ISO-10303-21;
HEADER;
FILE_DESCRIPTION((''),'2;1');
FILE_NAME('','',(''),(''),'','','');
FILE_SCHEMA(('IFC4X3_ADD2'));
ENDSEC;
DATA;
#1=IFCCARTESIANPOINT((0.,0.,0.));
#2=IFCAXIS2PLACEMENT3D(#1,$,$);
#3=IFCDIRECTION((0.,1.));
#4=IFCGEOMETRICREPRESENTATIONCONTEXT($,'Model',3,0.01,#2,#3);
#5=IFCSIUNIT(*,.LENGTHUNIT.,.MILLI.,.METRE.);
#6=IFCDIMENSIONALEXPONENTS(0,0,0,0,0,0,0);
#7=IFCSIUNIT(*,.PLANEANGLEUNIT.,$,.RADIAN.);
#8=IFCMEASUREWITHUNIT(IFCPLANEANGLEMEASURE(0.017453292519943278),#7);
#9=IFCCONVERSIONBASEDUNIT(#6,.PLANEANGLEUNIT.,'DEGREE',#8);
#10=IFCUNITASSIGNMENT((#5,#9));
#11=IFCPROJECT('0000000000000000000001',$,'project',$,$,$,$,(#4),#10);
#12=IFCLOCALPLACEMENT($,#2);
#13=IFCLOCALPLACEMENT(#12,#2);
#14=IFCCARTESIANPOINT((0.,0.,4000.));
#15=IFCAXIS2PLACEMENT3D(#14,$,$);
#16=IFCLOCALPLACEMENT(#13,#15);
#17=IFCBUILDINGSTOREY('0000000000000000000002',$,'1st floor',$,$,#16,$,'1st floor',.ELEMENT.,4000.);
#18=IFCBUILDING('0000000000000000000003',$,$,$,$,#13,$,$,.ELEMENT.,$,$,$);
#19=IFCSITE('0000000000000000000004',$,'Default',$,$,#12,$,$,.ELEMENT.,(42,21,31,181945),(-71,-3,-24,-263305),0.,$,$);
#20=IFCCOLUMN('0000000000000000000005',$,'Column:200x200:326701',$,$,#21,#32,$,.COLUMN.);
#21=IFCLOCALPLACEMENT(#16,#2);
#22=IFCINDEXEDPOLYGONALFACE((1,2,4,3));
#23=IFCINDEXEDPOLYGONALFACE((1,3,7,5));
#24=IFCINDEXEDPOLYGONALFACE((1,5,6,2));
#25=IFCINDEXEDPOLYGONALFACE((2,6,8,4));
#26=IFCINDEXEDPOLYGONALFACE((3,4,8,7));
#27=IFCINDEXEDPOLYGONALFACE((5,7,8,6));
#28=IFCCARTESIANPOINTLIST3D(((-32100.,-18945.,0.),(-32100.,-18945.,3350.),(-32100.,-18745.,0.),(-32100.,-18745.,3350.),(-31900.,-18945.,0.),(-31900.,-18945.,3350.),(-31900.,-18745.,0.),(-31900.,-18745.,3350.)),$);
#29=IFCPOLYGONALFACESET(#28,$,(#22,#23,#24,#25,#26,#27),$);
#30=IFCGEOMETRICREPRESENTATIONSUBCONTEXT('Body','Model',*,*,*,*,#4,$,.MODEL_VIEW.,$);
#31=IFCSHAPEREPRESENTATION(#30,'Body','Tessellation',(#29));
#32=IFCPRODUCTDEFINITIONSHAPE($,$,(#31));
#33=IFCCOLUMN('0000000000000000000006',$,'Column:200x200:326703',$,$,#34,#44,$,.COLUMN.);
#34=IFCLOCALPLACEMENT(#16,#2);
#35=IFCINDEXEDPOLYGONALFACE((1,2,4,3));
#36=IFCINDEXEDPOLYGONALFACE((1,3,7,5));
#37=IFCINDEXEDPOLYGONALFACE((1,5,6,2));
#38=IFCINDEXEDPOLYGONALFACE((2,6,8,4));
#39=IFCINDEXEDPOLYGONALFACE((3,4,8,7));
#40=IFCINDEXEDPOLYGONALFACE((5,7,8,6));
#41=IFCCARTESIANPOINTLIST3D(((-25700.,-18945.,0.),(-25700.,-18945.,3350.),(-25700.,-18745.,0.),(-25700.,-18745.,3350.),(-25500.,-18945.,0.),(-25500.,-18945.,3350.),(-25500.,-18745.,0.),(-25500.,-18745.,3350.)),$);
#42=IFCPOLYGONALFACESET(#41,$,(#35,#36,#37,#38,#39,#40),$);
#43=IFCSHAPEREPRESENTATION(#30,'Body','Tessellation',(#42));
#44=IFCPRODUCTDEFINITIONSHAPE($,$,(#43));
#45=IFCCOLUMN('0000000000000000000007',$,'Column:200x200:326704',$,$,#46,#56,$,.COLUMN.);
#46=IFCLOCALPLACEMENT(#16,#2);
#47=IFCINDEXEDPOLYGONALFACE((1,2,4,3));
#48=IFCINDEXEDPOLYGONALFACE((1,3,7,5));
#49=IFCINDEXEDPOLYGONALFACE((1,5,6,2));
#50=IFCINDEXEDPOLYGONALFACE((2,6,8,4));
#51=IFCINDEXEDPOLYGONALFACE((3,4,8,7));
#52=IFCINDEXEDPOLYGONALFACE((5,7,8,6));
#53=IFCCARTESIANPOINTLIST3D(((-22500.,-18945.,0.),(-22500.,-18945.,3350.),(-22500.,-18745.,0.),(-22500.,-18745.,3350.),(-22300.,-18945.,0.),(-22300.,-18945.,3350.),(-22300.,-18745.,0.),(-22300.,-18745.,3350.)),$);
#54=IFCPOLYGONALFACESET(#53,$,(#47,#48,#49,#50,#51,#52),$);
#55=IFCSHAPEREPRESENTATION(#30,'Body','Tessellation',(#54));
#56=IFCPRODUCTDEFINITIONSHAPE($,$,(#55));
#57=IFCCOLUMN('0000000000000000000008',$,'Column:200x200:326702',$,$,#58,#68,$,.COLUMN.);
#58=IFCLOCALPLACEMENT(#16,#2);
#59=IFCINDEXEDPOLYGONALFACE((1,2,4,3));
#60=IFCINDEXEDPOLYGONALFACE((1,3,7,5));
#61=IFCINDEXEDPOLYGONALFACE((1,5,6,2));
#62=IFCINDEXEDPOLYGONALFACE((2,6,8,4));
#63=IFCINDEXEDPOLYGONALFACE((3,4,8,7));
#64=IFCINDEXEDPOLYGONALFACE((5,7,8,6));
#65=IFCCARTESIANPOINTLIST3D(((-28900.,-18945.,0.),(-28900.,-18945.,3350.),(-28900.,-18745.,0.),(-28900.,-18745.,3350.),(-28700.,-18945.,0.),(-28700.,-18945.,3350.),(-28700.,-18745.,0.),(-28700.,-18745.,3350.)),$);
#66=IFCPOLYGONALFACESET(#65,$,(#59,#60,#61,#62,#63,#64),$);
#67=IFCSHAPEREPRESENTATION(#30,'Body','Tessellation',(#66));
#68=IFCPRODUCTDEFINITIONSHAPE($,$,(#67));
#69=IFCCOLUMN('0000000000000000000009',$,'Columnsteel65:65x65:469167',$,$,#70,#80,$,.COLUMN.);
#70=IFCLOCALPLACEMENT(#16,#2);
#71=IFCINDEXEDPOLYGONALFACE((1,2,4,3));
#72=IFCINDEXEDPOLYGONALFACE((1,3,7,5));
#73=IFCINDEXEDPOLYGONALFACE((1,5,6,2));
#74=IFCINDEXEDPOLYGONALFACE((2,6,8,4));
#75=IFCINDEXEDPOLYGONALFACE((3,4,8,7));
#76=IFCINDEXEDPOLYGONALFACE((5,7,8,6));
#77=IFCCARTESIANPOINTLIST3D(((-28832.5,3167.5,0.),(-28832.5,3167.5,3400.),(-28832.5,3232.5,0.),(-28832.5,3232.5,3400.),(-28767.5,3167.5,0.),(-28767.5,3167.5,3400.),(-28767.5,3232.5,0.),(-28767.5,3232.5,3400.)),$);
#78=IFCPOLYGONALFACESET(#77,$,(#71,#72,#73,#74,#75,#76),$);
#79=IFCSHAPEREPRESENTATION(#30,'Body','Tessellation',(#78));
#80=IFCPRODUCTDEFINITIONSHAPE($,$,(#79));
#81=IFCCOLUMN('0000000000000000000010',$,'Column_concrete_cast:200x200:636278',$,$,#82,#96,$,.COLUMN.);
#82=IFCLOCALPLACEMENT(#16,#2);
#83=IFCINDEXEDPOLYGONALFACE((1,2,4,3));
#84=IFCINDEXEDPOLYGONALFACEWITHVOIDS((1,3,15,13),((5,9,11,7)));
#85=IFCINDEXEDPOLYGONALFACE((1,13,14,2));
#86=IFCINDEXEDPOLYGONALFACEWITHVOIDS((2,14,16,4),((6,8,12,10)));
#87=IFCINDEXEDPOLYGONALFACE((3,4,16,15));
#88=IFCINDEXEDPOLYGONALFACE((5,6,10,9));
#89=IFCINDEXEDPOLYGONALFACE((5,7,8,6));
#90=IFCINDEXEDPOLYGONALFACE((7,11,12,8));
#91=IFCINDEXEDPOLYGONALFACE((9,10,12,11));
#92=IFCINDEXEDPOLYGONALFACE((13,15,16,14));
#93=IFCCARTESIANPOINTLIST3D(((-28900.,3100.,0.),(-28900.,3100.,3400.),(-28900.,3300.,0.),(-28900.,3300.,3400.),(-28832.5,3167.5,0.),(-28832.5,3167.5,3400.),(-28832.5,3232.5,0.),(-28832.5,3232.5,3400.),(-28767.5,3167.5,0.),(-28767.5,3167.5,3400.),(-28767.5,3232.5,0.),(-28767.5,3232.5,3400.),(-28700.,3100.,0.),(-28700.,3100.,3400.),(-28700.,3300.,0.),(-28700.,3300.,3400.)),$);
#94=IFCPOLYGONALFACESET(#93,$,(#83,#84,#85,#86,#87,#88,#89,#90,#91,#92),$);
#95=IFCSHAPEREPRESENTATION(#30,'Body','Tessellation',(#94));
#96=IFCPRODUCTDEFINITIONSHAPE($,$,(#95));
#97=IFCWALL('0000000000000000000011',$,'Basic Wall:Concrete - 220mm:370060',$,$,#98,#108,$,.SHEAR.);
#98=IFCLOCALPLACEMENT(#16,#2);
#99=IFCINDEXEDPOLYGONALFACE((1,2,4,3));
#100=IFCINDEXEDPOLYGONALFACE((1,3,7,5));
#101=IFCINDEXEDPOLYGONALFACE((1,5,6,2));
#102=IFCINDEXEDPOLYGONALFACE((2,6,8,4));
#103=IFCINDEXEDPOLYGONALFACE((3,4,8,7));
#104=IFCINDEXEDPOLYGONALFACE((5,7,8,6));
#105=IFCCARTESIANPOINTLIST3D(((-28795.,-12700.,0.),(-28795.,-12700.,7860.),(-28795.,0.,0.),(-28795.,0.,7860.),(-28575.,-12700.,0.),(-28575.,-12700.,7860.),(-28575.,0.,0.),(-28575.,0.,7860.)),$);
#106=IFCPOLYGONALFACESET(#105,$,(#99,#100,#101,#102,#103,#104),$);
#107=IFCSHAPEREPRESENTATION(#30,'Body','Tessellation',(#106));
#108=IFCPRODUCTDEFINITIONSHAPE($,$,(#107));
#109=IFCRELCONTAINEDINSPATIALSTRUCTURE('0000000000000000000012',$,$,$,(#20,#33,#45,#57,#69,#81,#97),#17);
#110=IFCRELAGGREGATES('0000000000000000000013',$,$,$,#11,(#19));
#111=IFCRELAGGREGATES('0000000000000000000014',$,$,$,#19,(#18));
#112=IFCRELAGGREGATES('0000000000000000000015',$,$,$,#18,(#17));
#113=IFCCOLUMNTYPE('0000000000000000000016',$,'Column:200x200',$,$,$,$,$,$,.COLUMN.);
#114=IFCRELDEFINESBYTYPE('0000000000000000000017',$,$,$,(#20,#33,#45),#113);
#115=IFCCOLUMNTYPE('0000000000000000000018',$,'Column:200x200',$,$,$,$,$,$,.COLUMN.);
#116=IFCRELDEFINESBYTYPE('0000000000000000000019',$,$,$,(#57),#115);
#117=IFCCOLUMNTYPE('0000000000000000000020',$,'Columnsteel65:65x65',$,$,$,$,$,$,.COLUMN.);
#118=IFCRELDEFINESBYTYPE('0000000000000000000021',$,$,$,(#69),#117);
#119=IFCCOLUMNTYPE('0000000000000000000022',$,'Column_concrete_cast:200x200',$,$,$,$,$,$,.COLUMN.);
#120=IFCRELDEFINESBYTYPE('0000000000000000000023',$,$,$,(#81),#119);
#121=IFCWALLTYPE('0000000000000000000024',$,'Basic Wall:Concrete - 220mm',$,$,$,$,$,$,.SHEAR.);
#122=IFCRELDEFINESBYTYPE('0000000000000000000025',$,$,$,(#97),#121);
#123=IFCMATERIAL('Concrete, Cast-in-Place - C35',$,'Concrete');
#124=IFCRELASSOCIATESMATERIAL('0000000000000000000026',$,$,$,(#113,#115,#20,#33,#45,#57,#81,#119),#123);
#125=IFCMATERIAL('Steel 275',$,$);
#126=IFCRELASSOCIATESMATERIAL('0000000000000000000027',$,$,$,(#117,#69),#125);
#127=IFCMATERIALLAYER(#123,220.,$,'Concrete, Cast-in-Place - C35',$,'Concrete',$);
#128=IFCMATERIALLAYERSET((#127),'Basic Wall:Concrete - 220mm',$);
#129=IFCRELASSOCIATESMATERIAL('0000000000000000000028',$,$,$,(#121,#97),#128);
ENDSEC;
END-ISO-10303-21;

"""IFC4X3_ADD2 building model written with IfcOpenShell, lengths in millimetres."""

from ifc_helpers import new_model, entity, si_unit, converted_unit, direction, frame, frame_2d, origin, place, context, subcontext, project, spatial, polyline, rectangle, outline, extrude, source, transform, mapped, material, layer, layer_set, material_profile, profile_set, profile_usage, type_object, type_shapes, element, save


model = new_model("IFC4X3_ADD2")

# Units and contexts
model_context = context("Model", 3, precision=0.01, world=origin(), true_north=direction((0.0, 1.0)))
body_context = subcontext(model_context, "Body", "Model", "MODEL_VIEW")
ifc_project = project(units=[si_unit("LENGTHUNIT", "METRE", prefix="MILLI"), converted_unit("PLANEANGLEUNIT", "DEGREE", entity("IfcPlaneAngleMeasure", 0.017453292519943278), si_unit("PLANEANGLEUNIT", "RADIAN"), dimensions=[0, 0, 0, 0, 0, 0, 0])], contexts=[model_context])

# Site, building, storey
site_placement = place(None, origin())
site = spatial("IfcSite", under=ifc_project, at=site_placement, Name="Default", CompositionType="ELEMENT", RefLatitude=(42, 21, 31, 181945), RefLongitude=(-71, -3, -24, -263305), RefElevation=0.0)
building_placement = place(site_placement, origin())
building = spatial("IfcBuilding", under=site, at=building_placement, CompositionType="ELEMENT")
storey_placement = place(building_placement, frame((0.0, 0.0, 4000.0)))
storey = spatial("IfcBuildingStorey", under=building, at=storey_placement, Name="1st floor", LongName="1st floor", CompositionType="ELEMENT", Elevation=4000.0)

# Columns
ifc_material_1 = material(Name="Concrete, Cast-in-Place - C35", Category="Concrete")
ifc_material_profile_1 = material_profile(ifc_material_1, rectangle(XDim=200.0, YDim=200.0, at=frame_2d((0.0, 0.0), x_axis=(1.0, 0.0))), Name="200x200")
ifc_profile_set_1 = profile_set([ifc_material_profile_1], Name="200x200")
ifc_profile_usage_1 = profile_usage(ifc_profile_set_1)
column_type_1 = type_object("IfcColumnType", Name="Column:200x200", PredefinedType="COLUMN", material=ifc_profile_set_1)
shared_shape_1 = source(origin(), body_context, "Body", "SweptSolid", [
    extrude(rectangle(XDim=200.0, YDim=200.0, at=frame_2d((0.0, 0.0), x_axis=(1.0, 0.0))), frame((0.0, 0.0, 4000.0), z_axis=(0.0, 0.0, 1.0), x_axis=(-1.0, 0.0, 0.0)), (0.0, 0.0, 1.0), 3350.0),
])
type_shapes(column_type_1, [shared_shape_1])
for number, where, name in (
    (1, (-32000.0, -18845.0, -4000.0), "Column:200x200:326701"),
    (2, (-25600.0, -18845.0, -4000.0), "Column:200x200:326703"),
    (3, (-22400.0, -18845.0, -4000.0), "Column:200x200:326704"),
):
    element("IfcColumn", number, at=place(storey_placement, frame(where)), inside=storey, type_object=column_type_1, material=ifc_profile_usage_1, Name=name, PredefinedType="COLUMN", context=body_context, shape_type="MappedRepresentation", body=[
        mapped(shared_shape_1, transform((0.0, 0.0, 0.0), scale=1.0)),
    ])
column_type_2 = type_object("IfcColumnType", Name="Column:200x200", PredefinedType="COLUMN", material=ifc_profile_set_1)
shared_shape_2 = source(origin(), body_context, "Body", "SweptSolid", [
    extrude(rectangle(XDim=200.0, YDim=200.0, at=frame_2d((0.0, 0.0), x_axis=(1.0, 0.0))), frame((0.0, 0.0, 4000.0), z_axis=(0.0, 0.0, 1.0), x_axis=(-1.0, 0.0, 0.0)), (0.0, 0.0, 1.0), 3350.0),
])
type_shapes(column_type_2, [shared_shape_2])
column_1_placement = place(storey_placement, frame((-28800.0, -18845.0, -4000.0)))
element("IfcColumn", 4, at=column_1_placement, inside=storey, type_object=column_type_2, material=ifc_profile_usage_1, Name="Column:200x200:326702", PredefinedType="COLUMN", context=body_context, shape_type="MappedRepresentation", body=[
    mapped(shared_shape_2, transform((0.0, 0.0, 0.0), scale=1.0)),
])
ifc_material_2 = material(Name="Steel 275")
ifc_material_profile_2 = material_profile(ifc_material_2, rectangle(XDim=65.0, YDim=65.0, at=frame_2d((0.0, 0.0), x_axis=(1.0, 0.0))), Name="65x65")
ifc_profile_set_2 = profile_set([ifc_material_profile_2], Name="65x65")
ifc_profile_usage_2 = profile_usage(ifc_profile_set_2)
column_type_3 = type_object("IfcColumnType", Name="Columnsteel65:65x65", PredefinedType="COLUMN", material=ifc_profile_set_2)
shared_shape_3 = source(origin(), body_context, "Body", "SweptSolid", [
    extrude(rectangle(XDim=65.0, YDim=65.0, at=frame_2d((0.0, 0.0), x_axis=(1.0, 0.0))), frame((0.0, 0.0, 4000.0), z_axis=(0.0, 0.0, 1.0), x_axis=(-1.0, 0.0, 0.0)), (0.0, 0.0, 1.0), 3400.0),
])
type_shapes(column_type_3, [shared_shape_3])
column_2_placement = place(storey_placement, frame((-28800.0, 3200.0, -4000.0)))
element("IfcColumn", 5, at=column_2_placement, inside=storey, type_object=column_type_3, material=ifc_profile_usage_2, Name="Columnsteel65:65x65:469167", PredefinedType="COLUMN", context=body_context, shape_type="MappedRepresentation", body=[
    mapped(shared_shape_3, transform((0.0, 0.0, 0.0), scale=1.0)),
])
ifc_material_profile_3 = material_profile(ifc_material_1, outline(polyline([(-100.0, -100.0), (100.0, -100.0), (100.0, 100.0), (-100.0, 100.0), (-100.0, -100.0)]), holes=[polyline([(-32.5, 32.5), (32.5, 32.5), (32.5, -32.5), (-32.5, -32.5), (-32.5, 32.5)])]), Name="200x200")
ifc_profile_set_3 = profile_set([ifc_material_profile_3], Name="200x200")
column_type_4 = type_object("IfcColumnType", Name="Column_concrete_cast:200x200", PredefinedType="COLUMN", material=ifc_profile_set_3)
shared_shape_4 = source(origin(), body_context, "Body", "SweptSolid", [
    extrude(outline(polyline([(-100.0, -100.0), (100.0, -100.0), (100.0, 100.0), (-100.0, 100.0), (-100.0, -100.0)]), holes=[polyline([(-32.5, 32.5), (32.5, 32.5), (32.5, -32.5), (-32.5, -32.5), (-32.5, 32.5)])]), frame((0.0, 0.0, 4000.0), z_axis=(0.0, 0.0, 1.0), x_axis=(-1.0, 0.0, 0.0)), (0.0, 0.0, 1.0), 3400.0),
])
type_shapes(column_type_4, [shared_shape_4])
column_3_placement = place(storey_placement, frame((-28800.0, 3200.0, -4000.0)))
element("IfcColumn", 6, at=column_3_placement, inside=storey, type_object=column_type_4, material=ifc_profile_usage_1, Name="Column_concrete_cast:200x200:636278", PredefinedType="COLUMN", context=body_context, shape_type="MappedRepresentation", body=[
    mapped(shared_shape_4, transform((0.0, 0.0, 0.0), scale=1.0)),
])

# Wall
ifc_layer_1 = layer(ifc_material_1, 220.0, Name="Concrete, Cast-in-Place - C35", Category="Concrete")
ifc_layer_set_1 = layer_set([ifc_layer_1], Name="Basic Wall:Concrete - 220mm")
wall_type = type_object("IfcWallType", Name="Basic Wall:Concrete - 220mm", PredefinedType="SHEAR", material=ifc_layer_set_1)
wall_placement = place(storey_placement, frame((-28685.0, 0.0, 0.0), z_axis=(0.0, 0.0, 1.0), x_axis=(0.0, -1.0, 0.0)))
element("IfcWall", 7, at=wall_placement, inside=storey, type_object=wall_type, material=ifc_layer_set_1, Name="Basic Wall:Concrete - 220mm:370060", PredefinedType="SHEAR", context=body_context, shape_type="SweptSolid", body=[
    extrude(rectangle(XDim=12700.0, YDim=220.0, at=frame_2d((6350.0, 0.0), x_axis=(-1.0, 0.0))), origin(), (0.0, 0.0, 1.0), 7860.0),
])

save(model, "model.ifc")
